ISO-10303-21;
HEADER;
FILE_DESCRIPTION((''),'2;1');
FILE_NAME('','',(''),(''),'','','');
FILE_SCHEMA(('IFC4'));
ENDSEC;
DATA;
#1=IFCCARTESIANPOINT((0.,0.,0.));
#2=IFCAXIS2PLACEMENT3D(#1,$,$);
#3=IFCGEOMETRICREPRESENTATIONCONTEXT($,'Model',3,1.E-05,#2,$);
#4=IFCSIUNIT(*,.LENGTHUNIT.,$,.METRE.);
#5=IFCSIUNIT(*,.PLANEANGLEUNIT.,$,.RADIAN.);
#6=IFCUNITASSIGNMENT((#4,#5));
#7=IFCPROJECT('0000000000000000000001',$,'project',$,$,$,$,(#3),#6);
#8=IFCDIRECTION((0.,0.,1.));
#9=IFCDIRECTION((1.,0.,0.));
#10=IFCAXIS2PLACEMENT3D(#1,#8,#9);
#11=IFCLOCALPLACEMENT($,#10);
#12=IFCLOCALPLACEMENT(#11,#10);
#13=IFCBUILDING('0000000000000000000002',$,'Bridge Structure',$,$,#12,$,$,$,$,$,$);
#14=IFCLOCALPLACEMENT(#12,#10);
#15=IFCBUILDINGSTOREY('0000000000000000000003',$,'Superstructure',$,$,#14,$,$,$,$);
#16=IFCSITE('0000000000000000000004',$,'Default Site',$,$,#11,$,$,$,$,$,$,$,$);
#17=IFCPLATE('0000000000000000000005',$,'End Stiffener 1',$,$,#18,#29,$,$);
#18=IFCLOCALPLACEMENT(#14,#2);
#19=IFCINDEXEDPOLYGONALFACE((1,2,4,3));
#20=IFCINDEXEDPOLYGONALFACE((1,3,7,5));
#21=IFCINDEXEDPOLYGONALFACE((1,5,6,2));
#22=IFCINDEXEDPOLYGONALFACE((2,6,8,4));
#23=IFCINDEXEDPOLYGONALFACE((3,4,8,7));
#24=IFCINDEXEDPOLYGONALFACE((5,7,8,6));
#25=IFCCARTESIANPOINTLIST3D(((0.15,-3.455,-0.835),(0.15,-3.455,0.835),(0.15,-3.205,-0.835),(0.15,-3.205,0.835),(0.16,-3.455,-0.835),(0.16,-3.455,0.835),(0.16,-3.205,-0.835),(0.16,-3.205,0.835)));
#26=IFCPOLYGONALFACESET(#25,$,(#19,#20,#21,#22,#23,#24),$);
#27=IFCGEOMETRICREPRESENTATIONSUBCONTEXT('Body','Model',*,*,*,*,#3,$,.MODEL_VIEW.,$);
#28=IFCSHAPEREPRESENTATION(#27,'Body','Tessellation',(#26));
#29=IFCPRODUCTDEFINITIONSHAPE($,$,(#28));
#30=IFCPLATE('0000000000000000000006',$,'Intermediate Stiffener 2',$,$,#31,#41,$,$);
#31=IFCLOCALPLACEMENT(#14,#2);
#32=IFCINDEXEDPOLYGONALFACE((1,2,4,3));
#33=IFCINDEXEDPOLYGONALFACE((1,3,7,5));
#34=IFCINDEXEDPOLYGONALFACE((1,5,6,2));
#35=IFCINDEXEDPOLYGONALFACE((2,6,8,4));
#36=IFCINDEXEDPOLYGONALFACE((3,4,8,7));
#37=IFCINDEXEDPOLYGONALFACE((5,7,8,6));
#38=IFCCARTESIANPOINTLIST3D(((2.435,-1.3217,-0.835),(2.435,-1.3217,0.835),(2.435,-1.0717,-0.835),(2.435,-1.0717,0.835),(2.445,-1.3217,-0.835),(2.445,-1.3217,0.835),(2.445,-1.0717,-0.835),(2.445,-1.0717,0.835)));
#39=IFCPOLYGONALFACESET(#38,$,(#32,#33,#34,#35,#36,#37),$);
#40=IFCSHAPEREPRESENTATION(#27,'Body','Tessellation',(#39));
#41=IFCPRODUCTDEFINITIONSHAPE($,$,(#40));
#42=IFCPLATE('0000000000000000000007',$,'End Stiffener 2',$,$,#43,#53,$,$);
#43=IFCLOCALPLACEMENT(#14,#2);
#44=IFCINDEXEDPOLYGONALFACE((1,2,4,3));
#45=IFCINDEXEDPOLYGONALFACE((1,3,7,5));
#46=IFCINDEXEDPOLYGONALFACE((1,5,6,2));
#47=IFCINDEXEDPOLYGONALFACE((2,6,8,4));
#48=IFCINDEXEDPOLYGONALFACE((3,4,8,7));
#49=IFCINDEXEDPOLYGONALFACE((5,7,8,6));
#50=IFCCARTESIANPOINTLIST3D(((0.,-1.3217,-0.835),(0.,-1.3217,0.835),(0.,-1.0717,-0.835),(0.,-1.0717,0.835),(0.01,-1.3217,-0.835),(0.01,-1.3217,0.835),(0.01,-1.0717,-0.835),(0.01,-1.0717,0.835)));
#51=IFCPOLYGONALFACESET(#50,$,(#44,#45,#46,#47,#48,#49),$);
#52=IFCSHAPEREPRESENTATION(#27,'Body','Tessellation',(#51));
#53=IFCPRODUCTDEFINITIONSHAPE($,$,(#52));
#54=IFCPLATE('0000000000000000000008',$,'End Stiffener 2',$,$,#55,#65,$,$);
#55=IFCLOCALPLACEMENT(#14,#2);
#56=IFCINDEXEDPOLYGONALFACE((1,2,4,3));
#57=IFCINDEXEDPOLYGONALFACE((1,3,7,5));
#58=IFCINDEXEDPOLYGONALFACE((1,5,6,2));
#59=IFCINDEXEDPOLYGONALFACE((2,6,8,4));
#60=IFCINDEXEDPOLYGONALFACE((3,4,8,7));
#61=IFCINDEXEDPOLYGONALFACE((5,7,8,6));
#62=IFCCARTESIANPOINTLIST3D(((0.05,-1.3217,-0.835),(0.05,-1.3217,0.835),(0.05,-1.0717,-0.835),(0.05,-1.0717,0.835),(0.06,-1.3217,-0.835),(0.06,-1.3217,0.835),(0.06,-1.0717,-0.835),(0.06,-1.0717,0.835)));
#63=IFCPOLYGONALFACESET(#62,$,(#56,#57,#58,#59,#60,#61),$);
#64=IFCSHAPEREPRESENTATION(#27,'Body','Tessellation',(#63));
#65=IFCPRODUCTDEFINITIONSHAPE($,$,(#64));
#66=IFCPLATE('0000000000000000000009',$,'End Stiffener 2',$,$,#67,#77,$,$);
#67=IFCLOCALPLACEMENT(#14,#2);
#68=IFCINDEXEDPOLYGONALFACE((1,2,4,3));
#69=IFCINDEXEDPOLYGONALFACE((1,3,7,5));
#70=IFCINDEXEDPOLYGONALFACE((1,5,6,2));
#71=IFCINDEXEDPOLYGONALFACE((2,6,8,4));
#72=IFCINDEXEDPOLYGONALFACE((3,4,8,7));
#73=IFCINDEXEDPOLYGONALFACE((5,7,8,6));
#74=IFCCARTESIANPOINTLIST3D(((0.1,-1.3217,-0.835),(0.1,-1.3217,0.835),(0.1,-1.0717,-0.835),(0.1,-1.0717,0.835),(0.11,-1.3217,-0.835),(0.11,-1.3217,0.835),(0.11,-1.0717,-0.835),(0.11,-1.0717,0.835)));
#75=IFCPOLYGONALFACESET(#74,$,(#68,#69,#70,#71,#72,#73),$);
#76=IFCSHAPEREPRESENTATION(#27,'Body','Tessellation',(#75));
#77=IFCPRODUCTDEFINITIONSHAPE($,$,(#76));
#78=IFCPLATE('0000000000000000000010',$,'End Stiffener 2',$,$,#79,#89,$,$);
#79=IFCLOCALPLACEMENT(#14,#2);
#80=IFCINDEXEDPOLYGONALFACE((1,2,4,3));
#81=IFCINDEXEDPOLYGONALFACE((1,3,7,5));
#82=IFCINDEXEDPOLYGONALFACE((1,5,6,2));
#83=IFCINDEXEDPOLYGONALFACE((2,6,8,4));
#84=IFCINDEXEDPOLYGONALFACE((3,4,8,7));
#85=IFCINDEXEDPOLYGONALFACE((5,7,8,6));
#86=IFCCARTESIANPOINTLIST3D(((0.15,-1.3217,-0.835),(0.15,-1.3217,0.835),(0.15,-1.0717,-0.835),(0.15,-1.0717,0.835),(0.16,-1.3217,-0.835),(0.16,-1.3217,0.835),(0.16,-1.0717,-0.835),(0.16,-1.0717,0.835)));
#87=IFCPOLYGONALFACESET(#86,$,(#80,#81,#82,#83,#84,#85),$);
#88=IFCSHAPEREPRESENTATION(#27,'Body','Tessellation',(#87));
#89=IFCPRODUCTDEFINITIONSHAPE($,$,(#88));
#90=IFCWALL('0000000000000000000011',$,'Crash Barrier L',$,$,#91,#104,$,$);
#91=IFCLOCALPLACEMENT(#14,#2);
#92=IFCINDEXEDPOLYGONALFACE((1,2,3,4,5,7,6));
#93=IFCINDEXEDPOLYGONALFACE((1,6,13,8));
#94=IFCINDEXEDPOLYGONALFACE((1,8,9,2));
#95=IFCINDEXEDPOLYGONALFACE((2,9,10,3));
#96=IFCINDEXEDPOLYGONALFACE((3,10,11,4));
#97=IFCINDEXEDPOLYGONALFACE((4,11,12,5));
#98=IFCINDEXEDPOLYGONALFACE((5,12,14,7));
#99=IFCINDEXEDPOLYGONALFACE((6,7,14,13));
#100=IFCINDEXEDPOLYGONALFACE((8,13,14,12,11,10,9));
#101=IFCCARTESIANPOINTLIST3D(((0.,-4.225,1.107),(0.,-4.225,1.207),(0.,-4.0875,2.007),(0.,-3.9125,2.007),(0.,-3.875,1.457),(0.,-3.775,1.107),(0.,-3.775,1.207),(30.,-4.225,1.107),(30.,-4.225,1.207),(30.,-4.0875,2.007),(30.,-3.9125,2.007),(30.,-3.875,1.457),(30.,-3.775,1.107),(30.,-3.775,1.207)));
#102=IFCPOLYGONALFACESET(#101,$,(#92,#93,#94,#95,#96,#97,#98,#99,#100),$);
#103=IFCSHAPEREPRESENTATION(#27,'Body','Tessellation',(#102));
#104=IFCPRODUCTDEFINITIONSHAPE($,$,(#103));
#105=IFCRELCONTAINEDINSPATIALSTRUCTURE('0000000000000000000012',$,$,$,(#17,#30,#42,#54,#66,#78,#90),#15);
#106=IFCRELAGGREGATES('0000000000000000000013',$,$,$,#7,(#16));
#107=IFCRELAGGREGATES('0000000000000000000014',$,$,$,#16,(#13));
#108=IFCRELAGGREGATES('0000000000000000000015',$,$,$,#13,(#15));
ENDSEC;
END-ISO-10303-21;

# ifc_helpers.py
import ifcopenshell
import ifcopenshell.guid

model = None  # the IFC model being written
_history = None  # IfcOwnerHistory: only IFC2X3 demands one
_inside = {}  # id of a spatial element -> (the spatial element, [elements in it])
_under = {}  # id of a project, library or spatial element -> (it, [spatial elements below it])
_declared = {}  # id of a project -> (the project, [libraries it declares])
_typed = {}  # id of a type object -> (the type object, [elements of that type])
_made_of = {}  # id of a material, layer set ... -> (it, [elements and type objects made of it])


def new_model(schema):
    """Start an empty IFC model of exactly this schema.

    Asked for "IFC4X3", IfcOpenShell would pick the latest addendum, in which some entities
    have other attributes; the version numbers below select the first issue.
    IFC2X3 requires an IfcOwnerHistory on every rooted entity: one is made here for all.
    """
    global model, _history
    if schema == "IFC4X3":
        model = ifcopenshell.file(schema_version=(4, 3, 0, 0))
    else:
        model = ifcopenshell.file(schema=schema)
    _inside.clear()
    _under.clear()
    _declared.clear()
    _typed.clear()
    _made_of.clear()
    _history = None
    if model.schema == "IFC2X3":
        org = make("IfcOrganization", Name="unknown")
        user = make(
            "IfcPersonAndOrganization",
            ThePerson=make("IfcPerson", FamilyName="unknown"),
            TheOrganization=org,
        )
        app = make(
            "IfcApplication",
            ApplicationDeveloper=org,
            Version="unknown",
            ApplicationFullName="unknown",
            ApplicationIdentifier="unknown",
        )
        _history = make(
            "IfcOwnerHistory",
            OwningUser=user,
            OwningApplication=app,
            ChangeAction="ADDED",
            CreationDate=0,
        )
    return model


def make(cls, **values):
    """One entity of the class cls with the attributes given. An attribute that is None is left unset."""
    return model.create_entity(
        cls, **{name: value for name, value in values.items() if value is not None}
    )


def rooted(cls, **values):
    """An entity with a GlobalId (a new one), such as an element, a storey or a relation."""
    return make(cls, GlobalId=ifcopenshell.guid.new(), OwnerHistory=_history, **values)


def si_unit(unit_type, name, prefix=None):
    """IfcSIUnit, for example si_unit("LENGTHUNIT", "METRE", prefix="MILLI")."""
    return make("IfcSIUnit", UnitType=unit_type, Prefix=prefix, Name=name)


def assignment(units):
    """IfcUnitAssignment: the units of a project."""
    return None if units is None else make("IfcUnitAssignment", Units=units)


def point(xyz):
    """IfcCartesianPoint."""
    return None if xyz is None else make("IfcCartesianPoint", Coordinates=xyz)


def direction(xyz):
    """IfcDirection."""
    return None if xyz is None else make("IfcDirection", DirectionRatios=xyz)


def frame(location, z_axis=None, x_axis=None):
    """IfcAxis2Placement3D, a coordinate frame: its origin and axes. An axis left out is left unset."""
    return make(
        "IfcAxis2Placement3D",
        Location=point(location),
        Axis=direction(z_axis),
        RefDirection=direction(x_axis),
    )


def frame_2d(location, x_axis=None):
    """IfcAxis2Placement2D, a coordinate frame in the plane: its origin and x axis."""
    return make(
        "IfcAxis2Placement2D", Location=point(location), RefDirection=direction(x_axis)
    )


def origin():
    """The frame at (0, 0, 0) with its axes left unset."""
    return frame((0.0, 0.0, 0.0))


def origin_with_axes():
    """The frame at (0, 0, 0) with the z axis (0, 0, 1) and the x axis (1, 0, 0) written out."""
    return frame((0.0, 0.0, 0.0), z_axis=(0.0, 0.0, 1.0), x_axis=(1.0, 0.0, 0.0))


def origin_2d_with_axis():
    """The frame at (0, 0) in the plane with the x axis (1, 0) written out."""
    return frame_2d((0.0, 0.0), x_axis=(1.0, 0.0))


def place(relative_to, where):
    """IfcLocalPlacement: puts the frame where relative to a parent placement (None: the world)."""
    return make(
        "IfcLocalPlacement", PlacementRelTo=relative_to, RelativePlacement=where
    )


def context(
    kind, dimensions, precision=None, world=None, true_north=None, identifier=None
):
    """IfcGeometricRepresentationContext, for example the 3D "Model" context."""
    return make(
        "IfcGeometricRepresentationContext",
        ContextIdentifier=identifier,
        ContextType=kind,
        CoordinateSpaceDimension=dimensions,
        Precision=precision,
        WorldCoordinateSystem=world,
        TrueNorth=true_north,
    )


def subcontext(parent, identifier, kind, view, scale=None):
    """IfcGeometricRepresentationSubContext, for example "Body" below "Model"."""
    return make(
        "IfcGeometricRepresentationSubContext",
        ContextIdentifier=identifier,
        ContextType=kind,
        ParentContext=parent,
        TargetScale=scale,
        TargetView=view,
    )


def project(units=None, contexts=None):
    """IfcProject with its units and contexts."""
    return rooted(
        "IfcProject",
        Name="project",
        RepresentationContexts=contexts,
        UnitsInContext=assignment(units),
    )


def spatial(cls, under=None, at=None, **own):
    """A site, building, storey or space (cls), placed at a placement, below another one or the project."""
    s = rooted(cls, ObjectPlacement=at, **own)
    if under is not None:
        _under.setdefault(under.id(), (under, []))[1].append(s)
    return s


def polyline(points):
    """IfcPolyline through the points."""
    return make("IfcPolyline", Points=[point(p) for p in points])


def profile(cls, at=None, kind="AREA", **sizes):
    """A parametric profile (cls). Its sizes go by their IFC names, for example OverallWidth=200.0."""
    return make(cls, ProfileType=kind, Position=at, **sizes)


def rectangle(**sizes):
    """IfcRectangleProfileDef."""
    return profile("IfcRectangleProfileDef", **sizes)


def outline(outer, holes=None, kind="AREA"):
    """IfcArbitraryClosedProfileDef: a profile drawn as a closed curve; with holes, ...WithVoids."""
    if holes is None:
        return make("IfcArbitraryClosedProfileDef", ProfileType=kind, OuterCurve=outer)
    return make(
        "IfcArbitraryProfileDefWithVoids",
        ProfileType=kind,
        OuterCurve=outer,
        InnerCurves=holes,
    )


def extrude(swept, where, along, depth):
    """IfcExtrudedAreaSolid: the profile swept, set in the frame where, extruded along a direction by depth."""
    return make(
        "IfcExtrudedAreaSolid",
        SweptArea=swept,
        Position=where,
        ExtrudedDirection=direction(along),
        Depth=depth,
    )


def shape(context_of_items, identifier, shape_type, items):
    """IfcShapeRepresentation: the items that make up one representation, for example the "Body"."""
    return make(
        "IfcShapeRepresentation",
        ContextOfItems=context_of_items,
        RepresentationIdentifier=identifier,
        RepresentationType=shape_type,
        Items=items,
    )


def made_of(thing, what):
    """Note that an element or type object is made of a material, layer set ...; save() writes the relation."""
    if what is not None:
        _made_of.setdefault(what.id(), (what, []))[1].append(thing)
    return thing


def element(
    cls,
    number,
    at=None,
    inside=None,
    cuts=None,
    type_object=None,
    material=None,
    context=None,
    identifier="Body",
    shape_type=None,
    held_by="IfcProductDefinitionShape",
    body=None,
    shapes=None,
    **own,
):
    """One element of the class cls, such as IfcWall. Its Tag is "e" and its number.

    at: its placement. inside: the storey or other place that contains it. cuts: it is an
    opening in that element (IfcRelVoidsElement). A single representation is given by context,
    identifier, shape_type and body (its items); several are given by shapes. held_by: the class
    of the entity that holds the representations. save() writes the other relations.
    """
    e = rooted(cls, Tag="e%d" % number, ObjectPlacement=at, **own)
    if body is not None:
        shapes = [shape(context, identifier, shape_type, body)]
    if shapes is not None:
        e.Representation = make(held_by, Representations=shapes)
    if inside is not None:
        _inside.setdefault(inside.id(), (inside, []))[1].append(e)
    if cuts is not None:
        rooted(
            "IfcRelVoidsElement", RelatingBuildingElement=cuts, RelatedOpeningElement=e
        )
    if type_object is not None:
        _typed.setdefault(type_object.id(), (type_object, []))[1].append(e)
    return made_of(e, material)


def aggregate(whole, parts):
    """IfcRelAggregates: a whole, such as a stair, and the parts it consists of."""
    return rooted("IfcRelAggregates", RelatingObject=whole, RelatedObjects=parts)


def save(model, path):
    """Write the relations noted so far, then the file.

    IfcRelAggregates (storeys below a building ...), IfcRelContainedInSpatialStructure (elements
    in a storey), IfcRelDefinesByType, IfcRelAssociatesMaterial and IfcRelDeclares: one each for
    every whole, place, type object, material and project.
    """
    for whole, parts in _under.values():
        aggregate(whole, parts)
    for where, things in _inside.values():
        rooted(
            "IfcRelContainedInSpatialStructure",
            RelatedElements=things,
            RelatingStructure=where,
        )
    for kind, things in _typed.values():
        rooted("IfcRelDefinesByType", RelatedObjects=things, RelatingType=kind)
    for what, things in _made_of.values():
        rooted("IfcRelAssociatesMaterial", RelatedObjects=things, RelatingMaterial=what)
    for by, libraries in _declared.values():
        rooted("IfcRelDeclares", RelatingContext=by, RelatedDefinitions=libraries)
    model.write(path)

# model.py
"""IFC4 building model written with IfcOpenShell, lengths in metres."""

from ifc_helpers import new_model, si_unit, frame, origin, origin_with_axes, origin_2d_with_axis, place, context, subcontext, project, spatial, polyline, rectangle, outline, extrude, element, save


model = new_model("IFC4")

# Units and contexts
model_context = context("Model", 3, precision=1e-05, world=origin())
body_context = subcontext(model_context, "Body", "Model", "MODEL_VIEW")
ifc_project = project(units=[si_unit("LENGTHUNIT", "METRE"), si_unit("PLANEANGLEUNIT", "RADIAN")], contexts=[model_context])

# Site, building, storey
site_placement = place(None, origin_with_axes())
site = spatial("IfcSite", under=ifc_project, at=site_placement, Name="Default Site")
building_placement = place(site_placement, origin_with_axes())
building = spatial("IfcBuilding", under=site, at=building_placement, Name="Bridge Structure")
storey_placement = place(building_placement, origin_with_axes())
storey = spatial("IfcBuildingStorey", under=building, at=storey_placement, Name="Superstructure")

# Plates
for number, where, z_axis, x_axis, name in (
    (1, (0.155, -3.33, -0.835), (0.0, 0.0, 1.0), (1.0, 0.0, 0.0), "End Stiffener 1"),
    (2, (2.44, -1.1967, -0.835), (0.0, 0.0, 1.0), (1.0, 0.0, 0.0), "Intermediate Stiffener 2"),
    (3, (0.005, -1.1967, -0.835), (0.0, 0.0, 1.0), (1.0, 0.0, 0.0), "End Stiffener 2"),
    (4, (0.055, -1.1967, -0.835), (0.0, 0.0, 1.0), (1.0, 0.0, 0.0), "End Stiffener 2"),
    (5, (0.105, -1.1967, -0.835), (0.0, 0.0, 1.0), (1.0, 0.0, 0.0), "End Stiffener 2"),
    (6, (0.155, -1.1967, -0.835), (0.0, 0.0, 1.0), (1.0, 0.0, 0.0), "End Stiffener 2"),
):
    element("IfcPlate", number, at=place(storey_placement, frame(where, z_axis=z_axis, x_axis=x_axis)), inside=storey, Name=name, context=body_context, shape_type="SweptSolid", body=[
        extrude(rectangle(XDim=0.01, YDim=0.25, at=origin_2d_with_axis()), origin_with_axes(), (0.0, 0.0, 1.0), 1.67),
    ])

# Wall
wall_placement = place(storey_placement, frame((0.0, -4.225, 1.107), z_axis=(1.0, 0.0, 0.0), x_axis=(0.0, 1.0, 0.0)))
element("IfcWall", 7, at=wall_placement, inside=storey, Name="Crash Barrier L", context=body_context, shape_type="SweptSolid", body=[
    extrude(outline(polyline([(0.0, 0.0), (0.45, 0.0), (0.45, 0.1), (0.35, 0.35), (0.3125, 0.9), (0.1375, 0.9), (0.0, 0.1), (0.0, 0.0)])), origin_with_axes(), (0.0, 0.0, 1.0), 30.0),
])

save(model, "model.ifc")
